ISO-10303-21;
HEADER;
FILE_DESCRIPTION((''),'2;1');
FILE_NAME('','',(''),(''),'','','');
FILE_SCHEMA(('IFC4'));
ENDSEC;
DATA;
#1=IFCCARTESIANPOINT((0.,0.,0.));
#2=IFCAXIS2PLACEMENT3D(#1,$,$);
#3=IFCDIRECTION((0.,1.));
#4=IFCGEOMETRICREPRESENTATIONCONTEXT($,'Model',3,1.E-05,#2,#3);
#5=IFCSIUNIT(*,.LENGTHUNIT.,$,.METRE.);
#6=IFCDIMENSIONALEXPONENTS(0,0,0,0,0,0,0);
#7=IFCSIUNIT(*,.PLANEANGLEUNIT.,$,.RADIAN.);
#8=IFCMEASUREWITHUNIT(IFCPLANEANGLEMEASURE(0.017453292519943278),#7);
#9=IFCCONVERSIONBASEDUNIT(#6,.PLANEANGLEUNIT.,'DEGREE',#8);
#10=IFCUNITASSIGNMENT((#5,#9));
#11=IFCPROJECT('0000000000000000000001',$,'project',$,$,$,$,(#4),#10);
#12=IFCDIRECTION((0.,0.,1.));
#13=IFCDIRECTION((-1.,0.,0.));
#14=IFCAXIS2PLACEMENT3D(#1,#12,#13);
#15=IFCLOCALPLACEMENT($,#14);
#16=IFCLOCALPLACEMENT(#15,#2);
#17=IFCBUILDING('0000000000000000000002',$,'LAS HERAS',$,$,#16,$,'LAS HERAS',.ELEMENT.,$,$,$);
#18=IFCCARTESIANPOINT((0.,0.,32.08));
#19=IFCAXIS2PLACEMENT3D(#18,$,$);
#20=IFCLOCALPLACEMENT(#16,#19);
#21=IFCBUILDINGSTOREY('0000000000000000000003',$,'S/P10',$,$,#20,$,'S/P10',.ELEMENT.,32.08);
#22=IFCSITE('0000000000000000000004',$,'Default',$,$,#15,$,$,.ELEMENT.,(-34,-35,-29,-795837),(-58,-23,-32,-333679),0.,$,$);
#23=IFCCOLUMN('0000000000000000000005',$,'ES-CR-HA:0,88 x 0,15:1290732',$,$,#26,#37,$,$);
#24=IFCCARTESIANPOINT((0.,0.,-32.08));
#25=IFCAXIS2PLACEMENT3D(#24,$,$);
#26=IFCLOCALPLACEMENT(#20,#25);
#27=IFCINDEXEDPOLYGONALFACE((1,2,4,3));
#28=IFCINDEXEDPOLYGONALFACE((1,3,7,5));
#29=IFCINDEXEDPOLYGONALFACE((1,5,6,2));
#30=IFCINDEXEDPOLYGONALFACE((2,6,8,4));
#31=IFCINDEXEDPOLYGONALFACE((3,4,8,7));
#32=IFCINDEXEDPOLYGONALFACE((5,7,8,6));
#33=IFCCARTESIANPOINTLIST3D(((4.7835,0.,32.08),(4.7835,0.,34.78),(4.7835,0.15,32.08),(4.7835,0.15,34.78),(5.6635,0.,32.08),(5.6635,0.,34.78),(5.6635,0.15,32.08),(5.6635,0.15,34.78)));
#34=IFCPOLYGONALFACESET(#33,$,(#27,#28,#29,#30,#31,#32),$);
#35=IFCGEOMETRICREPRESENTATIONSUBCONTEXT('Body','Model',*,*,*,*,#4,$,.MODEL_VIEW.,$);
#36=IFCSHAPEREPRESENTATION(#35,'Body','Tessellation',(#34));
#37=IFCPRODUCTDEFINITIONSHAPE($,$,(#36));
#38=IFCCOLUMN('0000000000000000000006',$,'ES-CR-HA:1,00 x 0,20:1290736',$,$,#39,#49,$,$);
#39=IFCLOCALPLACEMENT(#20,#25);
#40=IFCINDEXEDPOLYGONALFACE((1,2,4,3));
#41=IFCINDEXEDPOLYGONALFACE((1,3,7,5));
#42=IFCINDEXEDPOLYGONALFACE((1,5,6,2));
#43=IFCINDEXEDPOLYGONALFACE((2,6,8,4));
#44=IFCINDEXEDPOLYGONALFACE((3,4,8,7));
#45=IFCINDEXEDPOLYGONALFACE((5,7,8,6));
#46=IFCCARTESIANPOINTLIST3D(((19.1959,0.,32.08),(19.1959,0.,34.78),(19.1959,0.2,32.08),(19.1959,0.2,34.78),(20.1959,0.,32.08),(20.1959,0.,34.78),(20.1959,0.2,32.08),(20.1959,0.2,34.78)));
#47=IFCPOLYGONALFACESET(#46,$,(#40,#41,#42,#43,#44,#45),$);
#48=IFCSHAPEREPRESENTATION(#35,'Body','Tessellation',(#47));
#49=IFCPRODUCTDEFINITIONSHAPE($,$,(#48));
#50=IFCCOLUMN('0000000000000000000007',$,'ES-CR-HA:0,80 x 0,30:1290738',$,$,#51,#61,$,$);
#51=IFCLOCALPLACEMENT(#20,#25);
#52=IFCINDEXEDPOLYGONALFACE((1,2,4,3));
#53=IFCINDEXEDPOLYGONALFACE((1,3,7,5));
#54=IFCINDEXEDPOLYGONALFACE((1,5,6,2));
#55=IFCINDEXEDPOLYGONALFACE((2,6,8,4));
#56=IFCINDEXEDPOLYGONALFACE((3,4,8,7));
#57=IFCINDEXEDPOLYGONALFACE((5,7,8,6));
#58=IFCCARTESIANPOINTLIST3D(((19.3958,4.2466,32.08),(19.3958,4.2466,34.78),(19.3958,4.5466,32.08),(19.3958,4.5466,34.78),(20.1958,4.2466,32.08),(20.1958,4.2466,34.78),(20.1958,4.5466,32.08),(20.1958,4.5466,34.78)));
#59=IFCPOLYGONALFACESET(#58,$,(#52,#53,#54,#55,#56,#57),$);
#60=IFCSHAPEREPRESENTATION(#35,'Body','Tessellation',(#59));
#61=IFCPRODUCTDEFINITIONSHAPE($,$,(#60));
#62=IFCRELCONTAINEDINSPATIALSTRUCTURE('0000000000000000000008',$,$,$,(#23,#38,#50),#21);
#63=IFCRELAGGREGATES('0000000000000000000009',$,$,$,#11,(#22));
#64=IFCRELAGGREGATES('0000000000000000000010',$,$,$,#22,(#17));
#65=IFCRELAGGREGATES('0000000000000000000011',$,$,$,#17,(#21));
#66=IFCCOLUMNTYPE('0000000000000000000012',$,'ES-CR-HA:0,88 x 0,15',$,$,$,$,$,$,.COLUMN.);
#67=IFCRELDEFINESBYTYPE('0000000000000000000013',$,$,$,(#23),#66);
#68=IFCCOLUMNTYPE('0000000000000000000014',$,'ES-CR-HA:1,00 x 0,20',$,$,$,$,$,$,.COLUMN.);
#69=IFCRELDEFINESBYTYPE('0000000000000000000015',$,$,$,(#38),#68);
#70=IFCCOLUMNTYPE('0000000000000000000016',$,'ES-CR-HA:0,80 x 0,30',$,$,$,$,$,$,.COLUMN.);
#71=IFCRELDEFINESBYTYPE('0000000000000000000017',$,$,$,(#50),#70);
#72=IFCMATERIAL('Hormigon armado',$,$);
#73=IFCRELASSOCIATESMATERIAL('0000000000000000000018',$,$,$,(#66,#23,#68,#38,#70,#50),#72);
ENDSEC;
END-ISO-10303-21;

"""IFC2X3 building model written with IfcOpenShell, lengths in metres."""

from ifc_helpers import new_model, entity, si_unit, converted_unit, direction, frame, frame_2d, origin, origin_2d_with_axis, place, context, subcontext, project, spatial, rectangle, extrude, source, transform, mapped, material, type_object, type_shapes, element, save


model = new_model("IFC2X3")

# Units and contexts
model_context = context("Model", 3, precision=1e-05, world=origin(), true_north=direction((0.0, 1.0)))
body_context = subcontext(model_context, "Body", "Model", "MODEL_VIEW")
ifc_project = project(units=[si_unit("LENGTHUNIT", "METRE"), converted_unit("PLANEANGLEUNIT", "DEGREE", entity("IfcPlaneAngleMeasure", 0.017453292519943278), si_unit("PLANEANGLEUNIT", "RADIAN"), dimensions=[0, 0, 0, 0, 0, 0, 0])], contexts=[model_context])

# Site, building, storey
site_placement = place(None, frame((0.0, 0.0, 0.0), z_axis=(0.0, 0.0, 1.0), x_axis=(-1.0, 0.0, 0.0)))
site = spatial("IfcSite", under=ifc_project, at=site_placement, Name="Default", CompositionType="ELEMENT", RefLatitude=(-34, -35, -29, -795837), RefLongitude=(-58, -23, -32, -333679), RefElevation=0.0)
building_placement = place(site_placement, origin())
building = spatial("IfcBuilding", under=site, at=building_placement, Name="LAS HERAS", LongName="LAS HERAS", CompositionType="ELEMENT")
storey_placement = place(building_placement, frame((0.0, 0.0, 32.08)))
storey = spatial("IfcBuildingStorey", under=building, at=storey_placement, Name="S/P10", LongName="S/P10", CompositionType="ELEMENT", Elevation=32.08)

# Columns
ifc_material = material(Name="Hormigon armado")
column_type_1 = type_object("IfcColumnType", Name="ES-CR-HA:0,88 x 0,15", PredefinedType="COLUMN", material=ifc_material)
shared_shape_1 = source(origin(), body_context, "Body", "SweptSolid", [
    extrude(rectangle(XDim=2.7, YDim=0.15, at=origin_2d_with_axis()), frame((4.7835, 0.075, 33.43), z_axis=(1.0, 0.0, 0.0), x_axis=(0.0, 0.0, 1.0)), (0.0, 0.0, 1.0), 0.88),
])
type_shapes(column_type_1, [shared_shape_1])
column_1_placement = place(storey_placement, frame((0.0, 0.0, -32.08)))
element("IfcColumn", 1, at=column_1_placement, inside=storey, type_object=column_type_1, material=ifc_material, Name="ES-CR-HA:0,88 x 0,15:1290732", context=body_context, shape_type="MappedRepresentation", body=[
    mapped(shared_shape_1, transform((0.0, 0.0, 0.0), scale=1.0)),
])
column_type_2 = type_object("IfcColumnType", Name="ES-CR-HA:1,00 x 0,20", PredefinedType="COLUMN", material=ifc_material)
shared_shape_2 = source(origin(), body_context, "Body", "SweptSolid", [
    extrude(rectangle(XDim=2.7, YDim=0.2, at=frame_2d((0.0, 0.0), x_axis=(1.0, 0.0))), frame((19.1959, 0.1, 33.43), z_axis=(1.0, 0.0, 0.0), x_axis=(0.0, 0.0, 1.0)), (0.0, 0.0, 1.0), 1.0),
])
type_shapes(column_type_2, [shared_shape_2])
column_2_placement = place(storey_placement, frame((0.0, 0.0, -32.08)))
element("IfcColumn", 2, at=column_2_placement, inside=storey, type_object=column_type_2, material=ifc_material, Name="ES-CR-HA:1,00 x 0,20:1290736", context=body_context, shape_type="MappedRepresentation", body=[
    mapped(shared_shape_2, transform((0.0, 0.0, 0.0), scale=1.0)),
])
column_type_3 = type_object("IfcColumnType", Name="ES-CR-HA:0,80 x 0,30", PredefinedType="COLUMN", material=ifc_material)
shared_shape_3 = source(origin(), body_context, "Body", "SweptSolid", [
    extrude(rectangle(XDim=2.7, YDim=0.3, at=origin_2d_with_axis()), frame((19.3958, 4.3966, 33.43), z_axis=(1.0, 0.0, 0.0), x_axis=(0.0, 0.0, 1.0)), (0.0, 0.0, 1.0), 0.8),
])
type_shapes(column_type_3, [shared_shape_3])
column_3_placement = place(storey_placement, frame((0.0, 0.0, -32.08)))
element("IfcColumn", 3, at=column_3_placement, inside=storey, type_object=column_type_3, material=ifc_material, Name="ES-CR-HA:0,80 x 0,30:1290738", context=body_context, shape_type="MappedRepresentation", body=[
    mapped(shared_shape_3, transform((0.0, 0.0, 0.0), scale=1.0)),
])

save(model, "model.ifc")
